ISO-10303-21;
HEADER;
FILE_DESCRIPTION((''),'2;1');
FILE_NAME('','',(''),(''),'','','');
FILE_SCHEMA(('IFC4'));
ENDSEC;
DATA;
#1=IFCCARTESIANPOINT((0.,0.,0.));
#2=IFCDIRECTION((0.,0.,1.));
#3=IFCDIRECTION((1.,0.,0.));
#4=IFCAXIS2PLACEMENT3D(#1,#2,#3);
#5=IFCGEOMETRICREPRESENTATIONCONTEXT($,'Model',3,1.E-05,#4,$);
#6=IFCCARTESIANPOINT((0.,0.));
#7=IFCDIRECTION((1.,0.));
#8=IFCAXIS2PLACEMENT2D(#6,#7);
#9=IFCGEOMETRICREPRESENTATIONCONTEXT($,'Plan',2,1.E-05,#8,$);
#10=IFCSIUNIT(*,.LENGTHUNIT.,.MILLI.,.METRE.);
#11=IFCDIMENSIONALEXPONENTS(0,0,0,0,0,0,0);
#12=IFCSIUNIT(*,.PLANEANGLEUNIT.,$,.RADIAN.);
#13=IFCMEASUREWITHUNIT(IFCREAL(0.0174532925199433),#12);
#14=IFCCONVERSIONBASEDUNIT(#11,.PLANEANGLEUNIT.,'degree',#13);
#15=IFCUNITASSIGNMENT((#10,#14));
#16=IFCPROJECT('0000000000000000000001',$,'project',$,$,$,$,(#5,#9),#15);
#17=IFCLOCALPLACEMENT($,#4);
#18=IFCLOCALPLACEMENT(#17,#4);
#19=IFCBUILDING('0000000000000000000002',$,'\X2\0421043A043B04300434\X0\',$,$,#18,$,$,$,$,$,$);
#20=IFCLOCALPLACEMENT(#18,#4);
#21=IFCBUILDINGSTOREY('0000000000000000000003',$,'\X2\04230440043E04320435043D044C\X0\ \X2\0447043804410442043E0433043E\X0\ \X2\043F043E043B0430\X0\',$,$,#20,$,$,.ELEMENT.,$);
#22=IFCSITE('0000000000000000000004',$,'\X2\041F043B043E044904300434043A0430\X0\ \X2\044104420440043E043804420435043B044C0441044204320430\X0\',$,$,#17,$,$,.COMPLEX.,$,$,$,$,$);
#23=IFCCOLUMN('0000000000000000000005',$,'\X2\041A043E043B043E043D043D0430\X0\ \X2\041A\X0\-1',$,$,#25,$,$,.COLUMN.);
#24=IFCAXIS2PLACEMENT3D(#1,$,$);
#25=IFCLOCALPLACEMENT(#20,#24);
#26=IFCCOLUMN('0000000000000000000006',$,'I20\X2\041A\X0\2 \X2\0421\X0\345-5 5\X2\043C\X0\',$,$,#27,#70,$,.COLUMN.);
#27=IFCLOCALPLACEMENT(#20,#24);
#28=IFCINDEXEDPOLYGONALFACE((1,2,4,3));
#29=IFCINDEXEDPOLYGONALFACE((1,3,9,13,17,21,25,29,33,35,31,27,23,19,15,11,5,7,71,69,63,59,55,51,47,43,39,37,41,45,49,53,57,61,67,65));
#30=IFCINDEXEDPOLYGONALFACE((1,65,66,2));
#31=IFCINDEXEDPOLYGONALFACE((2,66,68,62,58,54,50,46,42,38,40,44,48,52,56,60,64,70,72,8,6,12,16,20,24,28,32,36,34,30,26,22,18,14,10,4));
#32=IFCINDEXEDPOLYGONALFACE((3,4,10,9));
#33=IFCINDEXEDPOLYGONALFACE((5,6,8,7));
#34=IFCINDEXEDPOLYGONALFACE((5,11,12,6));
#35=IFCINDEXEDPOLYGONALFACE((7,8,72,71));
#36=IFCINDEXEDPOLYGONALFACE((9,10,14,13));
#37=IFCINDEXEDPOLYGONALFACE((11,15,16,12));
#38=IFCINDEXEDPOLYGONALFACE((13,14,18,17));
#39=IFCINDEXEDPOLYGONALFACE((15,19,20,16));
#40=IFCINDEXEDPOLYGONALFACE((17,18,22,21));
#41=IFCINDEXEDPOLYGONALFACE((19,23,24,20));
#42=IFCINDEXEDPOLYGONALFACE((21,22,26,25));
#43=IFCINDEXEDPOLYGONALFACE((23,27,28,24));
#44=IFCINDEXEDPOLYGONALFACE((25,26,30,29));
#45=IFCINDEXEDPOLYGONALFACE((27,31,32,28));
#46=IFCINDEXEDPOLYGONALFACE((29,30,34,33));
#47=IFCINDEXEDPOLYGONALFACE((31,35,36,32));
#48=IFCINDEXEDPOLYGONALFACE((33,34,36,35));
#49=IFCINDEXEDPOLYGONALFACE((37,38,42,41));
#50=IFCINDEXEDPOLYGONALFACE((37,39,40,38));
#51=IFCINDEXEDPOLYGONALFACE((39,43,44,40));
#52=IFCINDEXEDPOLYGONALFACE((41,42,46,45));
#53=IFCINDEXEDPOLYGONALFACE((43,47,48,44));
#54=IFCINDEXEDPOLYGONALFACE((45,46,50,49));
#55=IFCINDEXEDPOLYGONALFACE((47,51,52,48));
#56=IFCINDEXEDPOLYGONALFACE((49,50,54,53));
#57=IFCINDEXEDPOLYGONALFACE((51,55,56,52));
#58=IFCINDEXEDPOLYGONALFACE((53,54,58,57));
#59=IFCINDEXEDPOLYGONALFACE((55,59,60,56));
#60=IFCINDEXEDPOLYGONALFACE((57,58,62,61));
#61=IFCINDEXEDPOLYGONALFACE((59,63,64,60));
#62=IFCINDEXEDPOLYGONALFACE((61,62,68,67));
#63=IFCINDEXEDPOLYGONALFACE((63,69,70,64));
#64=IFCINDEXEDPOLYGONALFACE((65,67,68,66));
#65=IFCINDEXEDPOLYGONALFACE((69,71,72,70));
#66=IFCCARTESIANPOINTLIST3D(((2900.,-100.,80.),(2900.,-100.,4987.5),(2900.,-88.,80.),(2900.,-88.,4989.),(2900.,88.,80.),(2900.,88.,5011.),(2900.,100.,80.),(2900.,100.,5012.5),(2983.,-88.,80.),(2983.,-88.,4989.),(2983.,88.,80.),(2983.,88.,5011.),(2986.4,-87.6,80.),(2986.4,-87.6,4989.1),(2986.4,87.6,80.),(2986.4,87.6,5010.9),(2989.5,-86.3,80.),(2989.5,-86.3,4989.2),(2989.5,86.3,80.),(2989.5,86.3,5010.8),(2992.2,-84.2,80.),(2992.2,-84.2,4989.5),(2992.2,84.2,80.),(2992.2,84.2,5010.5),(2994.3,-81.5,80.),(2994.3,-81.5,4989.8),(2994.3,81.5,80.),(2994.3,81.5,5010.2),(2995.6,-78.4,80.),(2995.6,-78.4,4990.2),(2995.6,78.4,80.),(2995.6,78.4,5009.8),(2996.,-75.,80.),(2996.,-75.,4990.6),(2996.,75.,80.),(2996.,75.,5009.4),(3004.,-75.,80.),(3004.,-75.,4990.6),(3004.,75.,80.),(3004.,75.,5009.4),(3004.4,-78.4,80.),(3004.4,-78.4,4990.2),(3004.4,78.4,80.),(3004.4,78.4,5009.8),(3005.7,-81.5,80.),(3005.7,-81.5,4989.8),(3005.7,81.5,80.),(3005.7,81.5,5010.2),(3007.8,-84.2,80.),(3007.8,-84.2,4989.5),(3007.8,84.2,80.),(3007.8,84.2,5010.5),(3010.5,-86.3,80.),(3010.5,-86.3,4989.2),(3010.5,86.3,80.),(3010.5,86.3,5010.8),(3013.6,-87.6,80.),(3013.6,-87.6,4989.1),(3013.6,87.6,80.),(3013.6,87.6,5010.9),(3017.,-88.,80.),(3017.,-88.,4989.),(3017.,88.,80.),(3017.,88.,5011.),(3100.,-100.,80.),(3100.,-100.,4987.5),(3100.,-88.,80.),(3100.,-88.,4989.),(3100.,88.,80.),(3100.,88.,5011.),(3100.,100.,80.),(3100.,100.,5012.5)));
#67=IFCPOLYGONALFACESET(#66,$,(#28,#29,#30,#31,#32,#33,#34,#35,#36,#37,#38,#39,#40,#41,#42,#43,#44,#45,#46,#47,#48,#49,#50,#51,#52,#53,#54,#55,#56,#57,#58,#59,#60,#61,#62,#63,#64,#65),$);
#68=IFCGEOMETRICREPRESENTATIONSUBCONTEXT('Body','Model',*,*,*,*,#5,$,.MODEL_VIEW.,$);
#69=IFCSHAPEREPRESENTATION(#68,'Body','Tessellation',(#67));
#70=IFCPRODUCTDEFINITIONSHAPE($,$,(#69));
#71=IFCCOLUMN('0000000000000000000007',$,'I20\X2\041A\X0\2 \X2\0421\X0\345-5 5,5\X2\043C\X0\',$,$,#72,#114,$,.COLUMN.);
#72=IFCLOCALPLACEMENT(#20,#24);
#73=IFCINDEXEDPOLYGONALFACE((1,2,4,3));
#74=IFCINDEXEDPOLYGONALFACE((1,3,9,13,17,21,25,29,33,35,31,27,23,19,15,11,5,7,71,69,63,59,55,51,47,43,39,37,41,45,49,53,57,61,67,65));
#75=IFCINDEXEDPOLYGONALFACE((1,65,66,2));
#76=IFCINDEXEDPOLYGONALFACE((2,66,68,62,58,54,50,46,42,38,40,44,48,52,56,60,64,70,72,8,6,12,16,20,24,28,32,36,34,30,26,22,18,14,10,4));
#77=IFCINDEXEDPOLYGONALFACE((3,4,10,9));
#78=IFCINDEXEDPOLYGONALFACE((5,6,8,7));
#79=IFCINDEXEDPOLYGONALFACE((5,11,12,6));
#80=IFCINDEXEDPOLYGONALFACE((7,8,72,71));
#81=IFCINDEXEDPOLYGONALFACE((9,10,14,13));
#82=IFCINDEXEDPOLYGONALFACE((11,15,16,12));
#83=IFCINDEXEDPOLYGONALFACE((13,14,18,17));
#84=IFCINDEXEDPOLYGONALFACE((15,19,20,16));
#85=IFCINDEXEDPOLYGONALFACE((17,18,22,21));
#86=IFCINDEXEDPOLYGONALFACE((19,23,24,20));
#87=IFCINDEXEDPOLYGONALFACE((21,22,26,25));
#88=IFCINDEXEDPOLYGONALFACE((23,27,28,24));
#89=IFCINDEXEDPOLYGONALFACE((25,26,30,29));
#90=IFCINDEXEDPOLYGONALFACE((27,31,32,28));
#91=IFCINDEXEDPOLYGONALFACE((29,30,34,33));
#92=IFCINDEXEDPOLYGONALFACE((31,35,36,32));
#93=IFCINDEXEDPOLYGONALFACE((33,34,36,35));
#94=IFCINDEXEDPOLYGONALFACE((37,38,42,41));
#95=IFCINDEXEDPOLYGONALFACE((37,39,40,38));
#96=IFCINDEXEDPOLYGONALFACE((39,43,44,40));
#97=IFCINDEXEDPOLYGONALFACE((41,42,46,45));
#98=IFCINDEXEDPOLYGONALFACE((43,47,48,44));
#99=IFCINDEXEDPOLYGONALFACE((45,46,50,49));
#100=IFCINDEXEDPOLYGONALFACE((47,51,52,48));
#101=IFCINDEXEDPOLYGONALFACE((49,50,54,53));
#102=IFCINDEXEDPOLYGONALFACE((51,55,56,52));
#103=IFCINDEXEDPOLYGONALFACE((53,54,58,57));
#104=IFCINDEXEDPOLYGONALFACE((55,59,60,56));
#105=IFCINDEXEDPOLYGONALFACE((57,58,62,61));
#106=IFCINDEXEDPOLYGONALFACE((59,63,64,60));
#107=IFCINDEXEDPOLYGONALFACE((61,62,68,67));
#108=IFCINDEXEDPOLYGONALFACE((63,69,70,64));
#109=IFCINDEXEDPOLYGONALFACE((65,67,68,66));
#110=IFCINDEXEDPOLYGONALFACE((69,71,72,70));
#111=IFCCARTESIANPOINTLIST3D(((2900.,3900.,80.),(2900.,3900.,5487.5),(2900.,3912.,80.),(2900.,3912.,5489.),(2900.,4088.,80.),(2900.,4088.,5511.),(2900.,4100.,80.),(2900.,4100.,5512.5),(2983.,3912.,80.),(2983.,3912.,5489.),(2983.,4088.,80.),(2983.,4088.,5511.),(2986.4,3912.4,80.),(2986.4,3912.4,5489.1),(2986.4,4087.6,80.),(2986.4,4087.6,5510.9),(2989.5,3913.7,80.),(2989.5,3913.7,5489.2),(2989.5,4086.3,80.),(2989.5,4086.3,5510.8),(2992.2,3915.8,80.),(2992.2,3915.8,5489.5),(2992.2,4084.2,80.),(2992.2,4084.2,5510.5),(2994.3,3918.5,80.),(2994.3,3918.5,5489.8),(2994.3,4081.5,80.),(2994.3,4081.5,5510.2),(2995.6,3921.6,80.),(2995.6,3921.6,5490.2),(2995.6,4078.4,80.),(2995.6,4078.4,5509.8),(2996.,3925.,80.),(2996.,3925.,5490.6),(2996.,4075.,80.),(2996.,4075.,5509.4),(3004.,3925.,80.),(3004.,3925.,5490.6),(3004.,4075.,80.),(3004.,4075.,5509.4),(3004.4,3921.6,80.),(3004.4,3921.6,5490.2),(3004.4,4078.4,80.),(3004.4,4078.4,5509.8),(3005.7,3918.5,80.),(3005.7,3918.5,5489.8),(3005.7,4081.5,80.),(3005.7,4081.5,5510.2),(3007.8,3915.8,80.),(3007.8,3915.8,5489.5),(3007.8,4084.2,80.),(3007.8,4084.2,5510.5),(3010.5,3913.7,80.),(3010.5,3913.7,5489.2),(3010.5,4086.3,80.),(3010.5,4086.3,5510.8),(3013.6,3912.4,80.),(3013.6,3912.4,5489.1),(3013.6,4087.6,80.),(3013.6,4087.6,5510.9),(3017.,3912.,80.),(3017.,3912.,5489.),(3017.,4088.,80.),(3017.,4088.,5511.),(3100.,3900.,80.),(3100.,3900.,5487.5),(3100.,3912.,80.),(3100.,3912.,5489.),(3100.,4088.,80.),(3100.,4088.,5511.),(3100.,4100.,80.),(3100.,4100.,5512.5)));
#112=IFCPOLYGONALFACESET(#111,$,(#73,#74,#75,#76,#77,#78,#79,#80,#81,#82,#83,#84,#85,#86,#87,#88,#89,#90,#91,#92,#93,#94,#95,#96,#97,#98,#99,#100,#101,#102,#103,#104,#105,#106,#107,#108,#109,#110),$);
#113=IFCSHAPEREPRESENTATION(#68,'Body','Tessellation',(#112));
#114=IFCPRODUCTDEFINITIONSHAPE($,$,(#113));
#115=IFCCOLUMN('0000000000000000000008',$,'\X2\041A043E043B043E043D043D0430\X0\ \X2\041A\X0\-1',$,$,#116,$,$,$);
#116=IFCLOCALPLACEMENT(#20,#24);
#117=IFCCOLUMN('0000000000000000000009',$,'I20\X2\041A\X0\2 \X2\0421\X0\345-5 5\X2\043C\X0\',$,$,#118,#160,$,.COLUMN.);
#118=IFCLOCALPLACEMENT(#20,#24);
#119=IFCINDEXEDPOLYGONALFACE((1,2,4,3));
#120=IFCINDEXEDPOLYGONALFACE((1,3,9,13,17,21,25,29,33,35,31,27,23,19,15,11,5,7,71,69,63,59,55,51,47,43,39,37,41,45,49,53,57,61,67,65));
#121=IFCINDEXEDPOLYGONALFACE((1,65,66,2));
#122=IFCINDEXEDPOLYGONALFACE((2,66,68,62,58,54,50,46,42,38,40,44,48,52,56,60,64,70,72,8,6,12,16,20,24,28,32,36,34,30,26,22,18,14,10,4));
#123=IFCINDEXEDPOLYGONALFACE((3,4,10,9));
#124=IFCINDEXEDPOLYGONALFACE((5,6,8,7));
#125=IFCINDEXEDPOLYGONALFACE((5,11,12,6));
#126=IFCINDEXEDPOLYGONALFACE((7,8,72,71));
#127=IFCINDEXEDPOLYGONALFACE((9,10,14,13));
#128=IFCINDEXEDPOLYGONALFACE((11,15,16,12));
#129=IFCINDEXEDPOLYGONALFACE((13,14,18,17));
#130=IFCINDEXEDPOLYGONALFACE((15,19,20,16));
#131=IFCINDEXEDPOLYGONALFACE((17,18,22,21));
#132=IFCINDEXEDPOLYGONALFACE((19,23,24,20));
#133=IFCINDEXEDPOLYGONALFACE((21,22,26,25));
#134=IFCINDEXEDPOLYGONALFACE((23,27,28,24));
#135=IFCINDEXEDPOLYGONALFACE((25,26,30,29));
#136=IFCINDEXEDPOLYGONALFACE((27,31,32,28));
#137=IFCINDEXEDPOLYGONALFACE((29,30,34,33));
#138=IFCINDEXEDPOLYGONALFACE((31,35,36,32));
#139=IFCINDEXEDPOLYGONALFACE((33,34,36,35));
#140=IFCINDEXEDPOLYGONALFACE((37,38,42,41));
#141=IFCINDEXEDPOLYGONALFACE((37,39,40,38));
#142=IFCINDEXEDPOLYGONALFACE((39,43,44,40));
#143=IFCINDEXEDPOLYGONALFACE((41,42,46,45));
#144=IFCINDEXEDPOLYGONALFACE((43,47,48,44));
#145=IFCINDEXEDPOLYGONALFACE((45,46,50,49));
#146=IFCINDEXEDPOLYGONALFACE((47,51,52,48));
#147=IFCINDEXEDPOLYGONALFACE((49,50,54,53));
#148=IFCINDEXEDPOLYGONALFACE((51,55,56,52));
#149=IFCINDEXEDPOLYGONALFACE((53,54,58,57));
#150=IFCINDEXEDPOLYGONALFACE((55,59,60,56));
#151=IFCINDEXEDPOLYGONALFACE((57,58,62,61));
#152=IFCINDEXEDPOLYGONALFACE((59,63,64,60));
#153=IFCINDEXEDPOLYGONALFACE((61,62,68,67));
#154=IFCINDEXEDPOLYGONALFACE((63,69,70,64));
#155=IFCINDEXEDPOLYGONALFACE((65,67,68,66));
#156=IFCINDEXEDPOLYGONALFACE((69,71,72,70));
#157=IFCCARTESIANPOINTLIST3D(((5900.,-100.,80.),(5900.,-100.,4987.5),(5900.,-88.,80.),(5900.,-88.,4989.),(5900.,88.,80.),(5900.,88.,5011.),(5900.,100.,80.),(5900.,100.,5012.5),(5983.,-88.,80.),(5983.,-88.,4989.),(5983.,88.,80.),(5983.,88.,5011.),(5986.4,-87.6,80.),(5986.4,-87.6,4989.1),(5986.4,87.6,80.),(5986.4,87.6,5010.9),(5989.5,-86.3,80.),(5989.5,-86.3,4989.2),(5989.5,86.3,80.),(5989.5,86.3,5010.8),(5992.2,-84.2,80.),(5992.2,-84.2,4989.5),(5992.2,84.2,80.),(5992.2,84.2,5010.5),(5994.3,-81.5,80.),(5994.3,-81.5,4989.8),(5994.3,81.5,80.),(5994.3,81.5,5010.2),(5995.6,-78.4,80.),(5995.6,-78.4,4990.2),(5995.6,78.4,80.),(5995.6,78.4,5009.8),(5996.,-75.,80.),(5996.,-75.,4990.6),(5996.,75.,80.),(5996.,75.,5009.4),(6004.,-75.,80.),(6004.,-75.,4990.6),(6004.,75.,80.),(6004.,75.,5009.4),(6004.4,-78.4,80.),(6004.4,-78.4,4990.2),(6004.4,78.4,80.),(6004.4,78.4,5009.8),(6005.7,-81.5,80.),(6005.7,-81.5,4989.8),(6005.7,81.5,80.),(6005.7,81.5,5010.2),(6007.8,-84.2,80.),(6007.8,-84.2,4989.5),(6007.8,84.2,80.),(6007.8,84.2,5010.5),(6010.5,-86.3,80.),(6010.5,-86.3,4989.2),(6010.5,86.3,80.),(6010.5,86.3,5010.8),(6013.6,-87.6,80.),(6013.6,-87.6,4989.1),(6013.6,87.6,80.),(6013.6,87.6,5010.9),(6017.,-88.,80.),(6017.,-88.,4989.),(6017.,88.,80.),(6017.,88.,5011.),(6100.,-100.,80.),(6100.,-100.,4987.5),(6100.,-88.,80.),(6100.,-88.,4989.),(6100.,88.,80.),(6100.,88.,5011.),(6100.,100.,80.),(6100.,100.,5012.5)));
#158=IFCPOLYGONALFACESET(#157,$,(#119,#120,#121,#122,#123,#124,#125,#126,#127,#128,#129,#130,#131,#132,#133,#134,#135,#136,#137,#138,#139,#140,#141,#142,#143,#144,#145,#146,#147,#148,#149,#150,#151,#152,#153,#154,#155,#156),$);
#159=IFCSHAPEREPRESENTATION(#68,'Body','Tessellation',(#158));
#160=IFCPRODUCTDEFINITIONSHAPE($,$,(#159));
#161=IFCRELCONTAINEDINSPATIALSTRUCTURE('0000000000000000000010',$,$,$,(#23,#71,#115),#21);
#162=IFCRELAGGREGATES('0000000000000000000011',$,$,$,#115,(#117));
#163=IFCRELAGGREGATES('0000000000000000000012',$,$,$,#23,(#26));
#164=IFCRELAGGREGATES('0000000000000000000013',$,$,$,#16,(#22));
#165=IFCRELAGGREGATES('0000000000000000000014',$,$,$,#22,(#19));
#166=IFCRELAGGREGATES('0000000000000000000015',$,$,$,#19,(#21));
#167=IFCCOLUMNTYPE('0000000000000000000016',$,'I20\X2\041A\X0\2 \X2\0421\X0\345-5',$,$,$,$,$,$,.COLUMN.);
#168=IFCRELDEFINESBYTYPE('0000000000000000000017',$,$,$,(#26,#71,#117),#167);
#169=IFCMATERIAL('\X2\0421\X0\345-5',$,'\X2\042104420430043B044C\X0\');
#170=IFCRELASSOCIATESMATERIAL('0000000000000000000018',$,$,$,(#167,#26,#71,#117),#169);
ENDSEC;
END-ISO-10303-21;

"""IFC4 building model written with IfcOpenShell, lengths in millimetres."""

from ifc_helpers import new_model, entity, si_unit, converted_unit, frame, origin_with_axes, origin_2d_with_axis, place, context, subcontext, project, spatial, i_section, extrude, boolean, clip, halfspace, material, material_profile, profile_set, profile_usage, type_object, element, aggregate, save


model = new_model("IFC4")

# Units and contexts
model_context = context("Model", 3, precision=1e-05, world=origin_with_axes())
plan_context = context("Plan", 2, precision=1e-05, world=origin_2d_with_axis())
body_context = subcontext(model_context, "Body", "Model", "MODEL_VIEW")
ifc_project = project(units=[si_unit("LENGTHUNIT", "METRE", prefix="MILLI"), converted_unit("PLANEANGLEUNIT", "degree", entity("IfcReal", 0.0174532925199433), si_unit("PLANEANGLEUNIT", "RADIAN"), dimensions=[0, 0, 0, 0, 0, 0, 0])], contexts=[model_context, plan_context])

# Site, building, storey
site_placement = place(None, origin_with_axes())
site = spatial("IfcSite", under=ifc_project, at=site_placement, Name="Площадка строительства", CompositionType="COMPLEX")
building_placement = place(site_placement, origin_with_axes())
building = spatial("IfcBuilding", under=site, at=building_placement, Name="Склад")
storey_placement = place(building_placement, origin_with_axes())
storey = spatial("IfcBuildingStorey", under=building, at=storey_placement, Name="Уровень чистого пола", CompositionType="ELEMENT")

# Columns
placement = place(storey_placement, origin_with_axes())
column_1 = element("IfcColumn", 1, at=placement, inside=storey, Name="Колонна К-1", PredefinedType="COLUMN")
ifc_material_1 = material(Name="С345-5", Category="Сталь")
ifc_material_profile_1 = material_profile(ifc_material_1, i_section(OverallWidth=200.0, OverallDepth=200.0, WebThickness=8.0, FlangeThickness=12.0, FilletRadius=13.0, FlangeEdgeRadius=0.0, FlangeSlope=0.0))
ifc_profile_set_1 = profile_set([ifc_material_profile_1], Name="I20К2_С345-5")
ifc_profile_usage_1 = profile_usage(ifc_profile_set_1, cardinal=5)
column_type = type_object("IfcColumnType", Name="I20К2 С345-5", PredefinedType="COLUMN", material=ifc_profile_set_1)
column_2_placement = place(placement, frame((3000.0, 0.0, 0.0), z_axis=(0.0, 0.0, 1.0), x_axis=(1.0, 0.0, 0.0)))
column_2 = element("IfcColumn", 2, at=column_2_placement, type_object=column_type, material=ifc_profile_usage_1, Name="I20К2 С345-5 5м", PredefinedType="COLUMN", context=body_context, shape_type="Clipping", body=[
    boolean("DIFFERENCE", clip(extrude(i_section(OverallWidth=200.0, OverallDepth=200.0, WebThickness=8.0, FlangeThickness=12.0, FilletRadius=13.0, FlangeEdgeRadius=0.0, FlangeSlope=0.0), origin_with_axes(), (0.0, 0.0, 1.0), 5200.0), halfspace(frame((0.0, -298.5, 4962.7), z_axis=(0.0, -0.124035, 0.992278), x_axis=(0.0, 0.992278, 0.124035)), False)), halfspace(frame((0.0, 0.0, 80.0), z_axis=(0.0, 0.0, -1.0), x_axis=(1.0, 0.0, 0.0)), False)),
])

# Column
column_3_placement = place(storey_placement, frame((3000.0, 4000.0, 0.0), z_axis=(0.0, 0.0, 1.0), x_axis=(1.0, 0.0, 0.0)))
element("IfcColumn", 3, at=column_3_placement, inside=storey, type_object=column_type, material=ifc_profile_usage_1, Name="I20К2 С345-5 5,5м", PredefinedType="COLUMN", context=body_context, shape_type="Clipping", body=[
    boolean("DIFFERENCE", clip(extrude(i_section(OverallWidth=200.0, OverallDepth=200.0, WebThickness=8.0, FlangeThickness=12.0, FilletRadius=13.0, FlangeEdgeRadius=0.0, FlangeSlope=0.0), origin_with_axes(), (0.0, 0.0, 1.0), 5700.0), halfspace(frame((0.0, -4298.5, 4962.7), z_axis=(0.0, -0.124035, 0.992278), x_axis=(0.0, 0.992278, 0.124035)), False)), halfspace(frame((0.0, 0.0, 80.0), z_axis=(0.0, 0.0, -1.0), x_axis=(1.0, 0.0, 0.0)), False)),
])

# Columns
column_4 = element("IfcColumn", 4, at=placement, inside=storey, Name="Колонна К-1")
column_5_placement = place(placement, frame((6000.0, 0.0, 0.0), z_axis=(0.0, 0.0, 1.0), x_axis=(1.0, 0.0, 0.0)))
column_5 = element("IfcColumn", 5, at=column_5_placement, type_object=column_type, material=ifc_profile_usage_1, Name="I20К2 С345-5 5м", PredefinedType="COLUMN", context=body_context, shape_type="Clipping", body=[
    boolean("DIFFERENCE", clip(extrude(i_section(OverallWidth=200.0, OverallDepth=200.0, WebThickness=8.0, FlangeThickness=12.0, FilletRadius=13.0, FlangeEdgeRadius=0.0, FlangeSlope=0.0), origin_with_axes(), (0.0, 0.0, 1.0), 5200.0), halfspace(frame((0.0, -298.5, 4962.7), z_axis=(0.0, -0.124035, 0.992278), x_axis=(0.0, 0.992278, 0.124035)), False)), halfspace(frame((0.0, 0.0, 80.0), z_axis=(0.0, 0.0, -1.0), x_axis=(1.0, 0.0, 0.0)), False)),
])

aggregate(column_4, [column_5])

aggregate(column_1, [column_2])

save(model, "model.ifc")
